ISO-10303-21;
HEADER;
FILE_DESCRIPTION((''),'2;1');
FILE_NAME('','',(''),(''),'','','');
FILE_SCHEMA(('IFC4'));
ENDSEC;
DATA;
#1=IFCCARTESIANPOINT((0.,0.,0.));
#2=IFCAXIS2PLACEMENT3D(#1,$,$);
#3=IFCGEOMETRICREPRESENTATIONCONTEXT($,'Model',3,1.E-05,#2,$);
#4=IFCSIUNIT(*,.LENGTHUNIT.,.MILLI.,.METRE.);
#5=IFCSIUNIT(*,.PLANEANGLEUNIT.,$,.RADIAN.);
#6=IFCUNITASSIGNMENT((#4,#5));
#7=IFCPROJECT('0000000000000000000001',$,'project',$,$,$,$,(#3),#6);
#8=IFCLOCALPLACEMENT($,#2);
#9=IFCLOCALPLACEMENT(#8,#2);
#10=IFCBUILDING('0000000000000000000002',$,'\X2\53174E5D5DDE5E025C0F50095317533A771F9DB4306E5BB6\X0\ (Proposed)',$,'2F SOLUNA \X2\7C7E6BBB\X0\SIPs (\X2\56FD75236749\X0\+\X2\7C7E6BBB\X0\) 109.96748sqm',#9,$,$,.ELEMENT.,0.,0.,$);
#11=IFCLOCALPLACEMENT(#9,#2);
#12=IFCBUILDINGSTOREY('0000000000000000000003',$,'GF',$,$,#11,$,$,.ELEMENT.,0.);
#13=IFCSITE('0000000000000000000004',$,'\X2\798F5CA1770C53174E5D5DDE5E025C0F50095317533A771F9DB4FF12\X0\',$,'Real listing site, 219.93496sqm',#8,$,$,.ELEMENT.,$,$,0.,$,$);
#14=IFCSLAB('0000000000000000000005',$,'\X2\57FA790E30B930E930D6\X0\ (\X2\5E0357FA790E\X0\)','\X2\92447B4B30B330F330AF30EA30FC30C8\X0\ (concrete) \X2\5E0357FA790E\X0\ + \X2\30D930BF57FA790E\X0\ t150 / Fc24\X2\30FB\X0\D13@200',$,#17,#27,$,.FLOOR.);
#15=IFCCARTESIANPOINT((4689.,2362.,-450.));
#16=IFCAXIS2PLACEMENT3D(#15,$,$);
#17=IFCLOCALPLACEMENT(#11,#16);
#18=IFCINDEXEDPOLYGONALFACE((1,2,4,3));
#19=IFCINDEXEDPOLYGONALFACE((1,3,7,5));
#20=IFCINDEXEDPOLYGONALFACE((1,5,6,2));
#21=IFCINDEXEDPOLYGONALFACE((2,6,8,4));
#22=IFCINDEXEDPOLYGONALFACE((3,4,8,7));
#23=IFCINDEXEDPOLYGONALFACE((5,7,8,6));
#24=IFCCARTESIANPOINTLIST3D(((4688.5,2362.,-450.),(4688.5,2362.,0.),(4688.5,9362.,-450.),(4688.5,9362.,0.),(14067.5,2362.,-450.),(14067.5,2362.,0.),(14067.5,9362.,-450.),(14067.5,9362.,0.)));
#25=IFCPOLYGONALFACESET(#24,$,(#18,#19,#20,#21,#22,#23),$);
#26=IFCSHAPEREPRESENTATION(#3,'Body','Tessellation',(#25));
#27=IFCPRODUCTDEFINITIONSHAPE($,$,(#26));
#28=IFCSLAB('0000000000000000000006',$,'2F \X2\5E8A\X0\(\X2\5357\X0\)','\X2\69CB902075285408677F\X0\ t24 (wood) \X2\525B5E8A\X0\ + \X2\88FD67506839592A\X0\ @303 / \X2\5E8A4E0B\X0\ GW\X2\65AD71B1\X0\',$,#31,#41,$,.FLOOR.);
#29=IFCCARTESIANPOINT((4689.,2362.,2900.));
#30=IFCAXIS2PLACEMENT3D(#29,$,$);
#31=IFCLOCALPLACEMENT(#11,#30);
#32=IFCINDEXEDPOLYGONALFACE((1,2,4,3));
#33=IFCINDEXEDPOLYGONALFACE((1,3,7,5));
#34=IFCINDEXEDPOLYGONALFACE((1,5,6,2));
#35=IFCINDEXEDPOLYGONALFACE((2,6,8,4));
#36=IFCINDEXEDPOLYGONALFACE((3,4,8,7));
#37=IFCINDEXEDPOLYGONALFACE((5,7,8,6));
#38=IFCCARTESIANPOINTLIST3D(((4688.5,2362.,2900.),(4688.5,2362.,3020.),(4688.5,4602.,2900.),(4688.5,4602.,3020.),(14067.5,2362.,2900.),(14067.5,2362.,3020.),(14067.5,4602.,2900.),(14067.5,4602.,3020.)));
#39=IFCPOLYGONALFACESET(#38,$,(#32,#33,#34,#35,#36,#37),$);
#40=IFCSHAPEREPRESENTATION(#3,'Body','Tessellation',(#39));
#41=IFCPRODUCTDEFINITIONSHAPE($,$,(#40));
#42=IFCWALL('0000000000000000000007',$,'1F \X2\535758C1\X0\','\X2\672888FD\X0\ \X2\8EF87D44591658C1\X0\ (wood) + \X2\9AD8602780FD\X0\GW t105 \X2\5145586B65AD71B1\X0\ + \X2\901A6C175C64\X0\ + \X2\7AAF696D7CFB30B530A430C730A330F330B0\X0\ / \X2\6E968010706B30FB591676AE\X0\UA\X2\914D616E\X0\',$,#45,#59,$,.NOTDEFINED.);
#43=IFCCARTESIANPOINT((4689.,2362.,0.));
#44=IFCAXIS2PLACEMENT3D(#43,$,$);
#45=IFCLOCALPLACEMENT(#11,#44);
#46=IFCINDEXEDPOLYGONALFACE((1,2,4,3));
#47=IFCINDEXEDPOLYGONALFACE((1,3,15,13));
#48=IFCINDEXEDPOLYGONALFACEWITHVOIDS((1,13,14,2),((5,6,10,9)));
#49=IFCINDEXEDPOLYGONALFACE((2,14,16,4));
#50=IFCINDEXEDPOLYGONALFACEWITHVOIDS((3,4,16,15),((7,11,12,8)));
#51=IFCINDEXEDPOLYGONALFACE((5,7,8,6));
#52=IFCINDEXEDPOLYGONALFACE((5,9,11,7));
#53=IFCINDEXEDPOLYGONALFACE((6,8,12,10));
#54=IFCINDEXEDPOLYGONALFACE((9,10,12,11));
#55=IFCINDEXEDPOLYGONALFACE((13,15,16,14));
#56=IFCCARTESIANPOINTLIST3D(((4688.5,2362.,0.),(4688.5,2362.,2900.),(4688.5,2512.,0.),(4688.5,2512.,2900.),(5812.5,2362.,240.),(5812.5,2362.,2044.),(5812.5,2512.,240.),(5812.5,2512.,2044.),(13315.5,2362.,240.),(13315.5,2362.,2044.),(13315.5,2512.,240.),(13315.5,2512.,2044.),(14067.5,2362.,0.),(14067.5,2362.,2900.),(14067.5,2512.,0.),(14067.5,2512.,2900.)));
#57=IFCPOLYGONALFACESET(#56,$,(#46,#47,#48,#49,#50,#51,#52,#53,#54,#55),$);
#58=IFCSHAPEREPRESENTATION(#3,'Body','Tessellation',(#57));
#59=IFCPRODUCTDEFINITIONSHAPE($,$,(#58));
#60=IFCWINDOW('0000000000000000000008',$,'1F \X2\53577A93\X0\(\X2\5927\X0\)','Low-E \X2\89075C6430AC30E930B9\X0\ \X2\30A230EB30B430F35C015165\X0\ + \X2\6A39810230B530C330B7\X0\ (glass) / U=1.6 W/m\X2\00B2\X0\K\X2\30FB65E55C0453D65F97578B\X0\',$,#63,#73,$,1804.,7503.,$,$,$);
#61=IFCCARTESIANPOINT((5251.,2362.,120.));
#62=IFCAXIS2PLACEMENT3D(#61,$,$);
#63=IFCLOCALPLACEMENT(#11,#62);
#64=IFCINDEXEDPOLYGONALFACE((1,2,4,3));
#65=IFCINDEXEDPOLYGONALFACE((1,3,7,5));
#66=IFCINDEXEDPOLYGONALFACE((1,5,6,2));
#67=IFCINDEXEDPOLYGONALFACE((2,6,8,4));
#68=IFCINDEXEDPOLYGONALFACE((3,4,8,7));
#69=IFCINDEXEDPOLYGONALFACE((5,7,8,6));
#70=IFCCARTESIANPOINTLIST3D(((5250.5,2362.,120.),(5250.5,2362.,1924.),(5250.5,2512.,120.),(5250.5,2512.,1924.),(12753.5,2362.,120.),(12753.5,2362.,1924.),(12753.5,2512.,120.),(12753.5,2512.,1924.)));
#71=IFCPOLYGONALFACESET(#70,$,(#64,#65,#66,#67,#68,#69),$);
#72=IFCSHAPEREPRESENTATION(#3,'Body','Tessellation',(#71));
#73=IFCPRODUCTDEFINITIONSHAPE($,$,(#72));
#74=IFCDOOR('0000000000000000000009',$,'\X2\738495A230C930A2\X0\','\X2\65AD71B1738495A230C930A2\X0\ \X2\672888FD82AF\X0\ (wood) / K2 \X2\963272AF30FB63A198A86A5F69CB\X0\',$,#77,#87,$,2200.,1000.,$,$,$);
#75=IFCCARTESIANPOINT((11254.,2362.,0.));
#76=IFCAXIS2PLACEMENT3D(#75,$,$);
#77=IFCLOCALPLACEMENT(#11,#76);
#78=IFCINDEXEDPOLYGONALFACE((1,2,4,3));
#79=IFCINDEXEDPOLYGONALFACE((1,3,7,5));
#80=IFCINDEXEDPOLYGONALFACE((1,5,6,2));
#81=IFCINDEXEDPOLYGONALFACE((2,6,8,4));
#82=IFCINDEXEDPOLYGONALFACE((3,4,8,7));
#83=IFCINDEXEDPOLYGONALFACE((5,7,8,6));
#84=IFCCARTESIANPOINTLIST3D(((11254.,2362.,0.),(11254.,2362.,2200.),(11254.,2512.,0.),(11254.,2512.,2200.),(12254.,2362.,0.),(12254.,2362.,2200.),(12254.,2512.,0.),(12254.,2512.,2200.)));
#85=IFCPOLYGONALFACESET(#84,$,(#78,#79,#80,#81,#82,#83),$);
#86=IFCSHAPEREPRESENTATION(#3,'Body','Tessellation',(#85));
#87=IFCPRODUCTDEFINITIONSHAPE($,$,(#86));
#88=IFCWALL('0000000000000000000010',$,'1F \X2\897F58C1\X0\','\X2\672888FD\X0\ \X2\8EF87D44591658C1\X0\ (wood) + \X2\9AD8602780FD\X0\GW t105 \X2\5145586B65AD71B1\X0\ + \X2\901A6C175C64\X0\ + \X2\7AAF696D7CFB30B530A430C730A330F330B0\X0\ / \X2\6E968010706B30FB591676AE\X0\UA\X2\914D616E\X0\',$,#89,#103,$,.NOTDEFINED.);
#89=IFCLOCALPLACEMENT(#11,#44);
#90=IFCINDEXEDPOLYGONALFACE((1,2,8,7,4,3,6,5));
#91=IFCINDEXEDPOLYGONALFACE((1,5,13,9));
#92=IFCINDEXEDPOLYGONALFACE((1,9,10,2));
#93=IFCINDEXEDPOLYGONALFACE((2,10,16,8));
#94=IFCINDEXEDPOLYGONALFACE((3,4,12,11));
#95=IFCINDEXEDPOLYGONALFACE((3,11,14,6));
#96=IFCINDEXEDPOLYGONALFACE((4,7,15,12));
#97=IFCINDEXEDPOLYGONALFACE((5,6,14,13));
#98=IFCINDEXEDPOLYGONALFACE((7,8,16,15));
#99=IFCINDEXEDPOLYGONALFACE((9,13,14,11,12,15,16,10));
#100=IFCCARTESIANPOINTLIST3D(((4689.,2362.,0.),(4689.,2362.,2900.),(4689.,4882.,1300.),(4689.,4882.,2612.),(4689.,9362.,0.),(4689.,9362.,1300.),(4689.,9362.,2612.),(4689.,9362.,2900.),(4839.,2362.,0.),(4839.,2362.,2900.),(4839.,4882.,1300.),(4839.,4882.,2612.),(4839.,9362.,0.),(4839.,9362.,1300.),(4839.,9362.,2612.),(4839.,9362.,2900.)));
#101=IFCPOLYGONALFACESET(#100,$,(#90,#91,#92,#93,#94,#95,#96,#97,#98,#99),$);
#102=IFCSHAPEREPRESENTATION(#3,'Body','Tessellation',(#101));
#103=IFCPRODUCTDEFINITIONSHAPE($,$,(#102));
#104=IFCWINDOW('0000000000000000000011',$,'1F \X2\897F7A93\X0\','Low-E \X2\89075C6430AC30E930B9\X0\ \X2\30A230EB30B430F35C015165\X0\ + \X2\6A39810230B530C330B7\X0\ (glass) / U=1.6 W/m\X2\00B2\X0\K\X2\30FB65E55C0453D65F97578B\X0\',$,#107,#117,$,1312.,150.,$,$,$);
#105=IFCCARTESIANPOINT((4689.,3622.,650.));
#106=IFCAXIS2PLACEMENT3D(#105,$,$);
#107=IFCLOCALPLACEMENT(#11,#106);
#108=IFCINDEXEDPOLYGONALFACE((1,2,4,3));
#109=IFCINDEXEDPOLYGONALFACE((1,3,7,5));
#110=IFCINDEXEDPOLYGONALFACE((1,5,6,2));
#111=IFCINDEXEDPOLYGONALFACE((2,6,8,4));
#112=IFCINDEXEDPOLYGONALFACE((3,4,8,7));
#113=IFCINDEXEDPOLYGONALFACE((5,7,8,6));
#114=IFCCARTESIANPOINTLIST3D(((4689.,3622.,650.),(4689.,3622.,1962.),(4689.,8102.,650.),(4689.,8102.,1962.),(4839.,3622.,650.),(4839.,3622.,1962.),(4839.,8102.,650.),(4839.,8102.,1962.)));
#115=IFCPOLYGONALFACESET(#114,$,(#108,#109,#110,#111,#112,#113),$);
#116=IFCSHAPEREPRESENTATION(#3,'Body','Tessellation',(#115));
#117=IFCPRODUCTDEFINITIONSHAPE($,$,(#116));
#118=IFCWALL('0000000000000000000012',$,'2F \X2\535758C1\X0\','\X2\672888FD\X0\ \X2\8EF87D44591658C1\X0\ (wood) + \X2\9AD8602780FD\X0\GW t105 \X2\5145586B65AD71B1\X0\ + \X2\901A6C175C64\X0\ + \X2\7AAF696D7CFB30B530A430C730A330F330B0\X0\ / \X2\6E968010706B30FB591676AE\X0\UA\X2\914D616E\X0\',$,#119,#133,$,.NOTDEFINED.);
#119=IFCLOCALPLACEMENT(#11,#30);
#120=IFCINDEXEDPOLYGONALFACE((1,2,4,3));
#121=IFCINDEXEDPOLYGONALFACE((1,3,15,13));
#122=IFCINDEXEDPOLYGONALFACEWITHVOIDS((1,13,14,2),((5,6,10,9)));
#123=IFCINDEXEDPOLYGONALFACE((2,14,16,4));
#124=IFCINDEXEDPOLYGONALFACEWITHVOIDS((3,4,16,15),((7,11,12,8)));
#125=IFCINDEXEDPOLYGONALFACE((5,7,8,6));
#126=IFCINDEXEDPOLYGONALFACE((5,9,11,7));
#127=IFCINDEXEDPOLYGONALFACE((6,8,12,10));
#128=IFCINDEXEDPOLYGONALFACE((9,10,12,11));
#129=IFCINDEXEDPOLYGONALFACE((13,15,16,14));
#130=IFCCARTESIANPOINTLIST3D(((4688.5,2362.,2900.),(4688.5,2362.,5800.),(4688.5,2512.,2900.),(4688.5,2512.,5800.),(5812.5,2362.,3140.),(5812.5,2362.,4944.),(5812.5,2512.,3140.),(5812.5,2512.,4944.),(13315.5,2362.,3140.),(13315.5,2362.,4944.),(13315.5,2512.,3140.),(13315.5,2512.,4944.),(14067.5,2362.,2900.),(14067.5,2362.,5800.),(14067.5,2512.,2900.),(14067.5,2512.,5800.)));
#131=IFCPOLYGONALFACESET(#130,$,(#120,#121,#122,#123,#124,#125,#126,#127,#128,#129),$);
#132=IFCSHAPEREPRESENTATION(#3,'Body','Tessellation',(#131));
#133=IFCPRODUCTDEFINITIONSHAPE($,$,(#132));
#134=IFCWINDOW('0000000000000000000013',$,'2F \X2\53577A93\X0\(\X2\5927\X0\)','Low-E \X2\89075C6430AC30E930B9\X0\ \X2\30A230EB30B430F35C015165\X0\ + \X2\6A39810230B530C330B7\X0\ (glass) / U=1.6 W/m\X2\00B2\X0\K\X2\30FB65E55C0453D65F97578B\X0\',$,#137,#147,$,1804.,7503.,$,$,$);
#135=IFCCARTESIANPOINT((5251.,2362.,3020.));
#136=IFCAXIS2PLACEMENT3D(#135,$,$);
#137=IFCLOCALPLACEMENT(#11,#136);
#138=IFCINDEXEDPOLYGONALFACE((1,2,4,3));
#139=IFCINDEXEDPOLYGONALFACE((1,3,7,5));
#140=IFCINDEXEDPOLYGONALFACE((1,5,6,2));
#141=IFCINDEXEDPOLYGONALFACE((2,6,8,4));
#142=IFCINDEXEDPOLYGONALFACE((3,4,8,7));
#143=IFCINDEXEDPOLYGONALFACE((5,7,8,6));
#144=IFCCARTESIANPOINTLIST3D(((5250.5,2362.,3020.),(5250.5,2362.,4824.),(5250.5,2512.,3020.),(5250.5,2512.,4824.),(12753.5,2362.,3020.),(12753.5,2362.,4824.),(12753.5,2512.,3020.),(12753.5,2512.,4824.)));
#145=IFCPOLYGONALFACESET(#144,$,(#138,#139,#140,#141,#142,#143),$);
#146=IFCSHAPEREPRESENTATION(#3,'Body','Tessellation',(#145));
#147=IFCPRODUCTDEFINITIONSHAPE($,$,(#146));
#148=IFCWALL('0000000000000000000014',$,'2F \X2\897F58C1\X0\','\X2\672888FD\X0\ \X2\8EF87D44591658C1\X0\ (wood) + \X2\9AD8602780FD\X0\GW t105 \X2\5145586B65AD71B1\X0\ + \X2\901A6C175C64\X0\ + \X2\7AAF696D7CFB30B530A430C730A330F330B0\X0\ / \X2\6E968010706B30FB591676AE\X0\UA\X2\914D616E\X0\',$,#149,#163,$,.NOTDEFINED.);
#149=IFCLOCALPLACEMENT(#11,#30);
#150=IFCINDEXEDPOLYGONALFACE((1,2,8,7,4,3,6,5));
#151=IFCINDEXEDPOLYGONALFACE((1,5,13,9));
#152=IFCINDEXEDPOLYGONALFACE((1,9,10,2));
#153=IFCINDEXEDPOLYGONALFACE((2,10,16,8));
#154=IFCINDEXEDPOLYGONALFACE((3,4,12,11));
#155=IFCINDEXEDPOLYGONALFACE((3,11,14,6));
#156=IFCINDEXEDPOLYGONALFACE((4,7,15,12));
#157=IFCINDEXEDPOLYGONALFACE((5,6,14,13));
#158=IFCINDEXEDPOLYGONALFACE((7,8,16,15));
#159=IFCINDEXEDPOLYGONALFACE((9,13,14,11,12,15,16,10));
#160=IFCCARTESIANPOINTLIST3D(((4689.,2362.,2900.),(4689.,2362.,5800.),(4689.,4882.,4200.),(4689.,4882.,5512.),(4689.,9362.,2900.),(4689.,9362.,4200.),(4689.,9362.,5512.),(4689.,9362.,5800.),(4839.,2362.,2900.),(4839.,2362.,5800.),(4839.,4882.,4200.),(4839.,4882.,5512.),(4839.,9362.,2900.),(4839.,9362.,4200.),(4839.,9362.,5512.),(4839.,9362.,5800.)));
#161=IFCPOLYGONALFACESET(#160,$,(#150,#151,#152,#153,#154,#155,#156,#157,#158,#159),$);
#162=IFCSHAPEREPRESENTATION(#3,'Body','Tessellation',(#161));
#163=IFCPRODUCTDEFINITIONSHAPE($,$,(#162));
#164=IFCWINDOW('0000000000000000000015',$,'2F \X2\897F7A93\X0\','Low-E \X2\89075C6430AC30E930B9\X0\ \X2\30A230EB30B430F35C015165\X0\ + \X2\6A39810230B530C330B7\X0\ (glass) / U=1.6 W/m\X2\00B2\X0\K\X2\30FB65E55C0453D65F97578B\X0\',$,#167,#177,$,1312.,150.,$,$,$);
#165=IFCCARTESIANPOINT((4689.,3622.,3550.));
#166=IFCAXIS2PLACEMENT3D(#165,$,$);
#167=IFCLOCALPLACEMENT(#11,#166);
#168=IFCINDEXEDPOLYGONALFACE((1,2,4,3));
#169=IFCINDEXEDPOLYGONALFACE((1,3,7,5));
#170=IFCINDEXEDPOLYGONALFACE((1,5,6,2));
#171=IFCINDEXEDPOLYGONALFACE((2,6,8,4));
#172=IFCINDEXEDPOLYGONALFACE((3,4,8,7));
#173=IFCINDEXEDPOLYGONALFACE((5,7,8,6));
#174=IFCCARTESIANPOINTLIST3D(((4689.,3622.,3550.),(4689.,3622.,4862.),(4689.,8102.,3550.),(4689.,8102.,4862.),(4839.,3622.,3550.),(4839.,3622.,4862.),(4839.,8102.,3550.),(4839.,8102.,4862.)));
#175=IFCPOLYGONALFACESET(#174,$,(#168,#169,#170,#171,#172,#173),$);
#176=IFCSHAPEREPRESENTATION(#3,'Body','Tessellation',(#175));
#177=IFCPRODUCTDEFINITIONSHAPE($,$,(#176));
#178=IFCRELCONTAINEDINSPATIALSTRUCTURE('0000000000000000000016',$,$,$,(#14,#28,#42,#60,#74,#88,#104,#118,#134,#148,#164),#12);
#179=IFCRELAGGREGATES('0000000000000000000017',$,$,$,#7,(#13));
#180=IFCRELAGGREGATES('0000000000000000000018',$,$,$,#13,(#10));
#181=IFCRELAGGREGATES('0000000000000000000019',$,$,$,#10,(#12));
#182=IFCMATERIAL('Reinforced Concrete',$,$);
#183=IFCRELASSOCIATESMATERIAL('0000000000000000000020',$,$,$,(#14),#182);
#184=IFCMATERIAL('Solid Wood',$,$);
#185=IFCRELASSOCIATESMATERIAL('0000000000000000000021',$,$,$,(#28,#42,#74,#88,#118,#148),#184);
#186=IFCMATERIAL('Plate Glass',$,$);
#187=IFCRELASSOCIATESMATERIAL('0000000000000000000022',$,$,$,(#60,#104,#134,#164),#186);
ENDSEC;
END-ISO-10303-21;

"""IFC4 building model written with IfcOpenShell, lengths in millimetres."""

from ifc_helpers import new_model, si_unit, frame, frame_2d, origin, place, context, project, spatial, rectangle, extrude, material, element, fill, save


model = new_model("IFC4")

# Units and contexts
model_context = context("Model", 3, precision=1e-05, world=origin())
ifc_project = project(units=[si_unit("LENGTHUNIT", "METRE", prefix="MILLI"), si_unit("PLANEANGLEUNIT", "RADIAN")], contexts=[model_context])

# Site, building, storey
site_placement = place(None, origin())
site = spatial("IfcSite", under=ifc_project, at=site_placement, Name="福岡県北九州市小倉北区真鶴２", ObjectType="Real listing site, 219.93496sqm", CompositionType="ELEMENT", RefElevation=0.0)
building_placement = place(site_placement, origin())
building = spatial("IfcBuilding", under=site, at=building_placement, Name="北九州市小倉北区真鶴の家 (Proposed)", ObjectType="2F SOLUNA 籾殻SIPs (国産杉+籾殻) 109.96748sqm", CompositionType="ELEMENT", ElevationOfRefHeight=0.0, ElevationOfTerrain=0.0)
storey_placement = place(building_placement, origin())
storey = spatial("IfcBuildingStorey", under=building, at=storey_placement, Name="GF", CompositionType="ELEMENT", Elevation=0.0)

# Slabs
ifc_material_1 = material(Name="Reinforced Concrete")
slab_1_placement = place(storey_placement, frame((4689.0, 2362.0, -450.0)))
element("IfcSlab", 1, at=slab_1_placement, inside=storey, material=ifc_material_1, Name="基礎スラブ (布基礎)", Description="鉄筋コンクリート (concrete) 布基礎 + ベタ基礎 t150 / Fc24・D13@200", PredefinedType="FLOOR", context=model_context, shape_type="SweptSolid", body=[
    extrude(rectangle(XDim=9379.0, YDim=7000.0, at=frame_2d((4689.0, 3500.0))), frame((4689.0, 2362.0, -450.0)), (0.0, 0.0, 1.0), 450.0),
])
ifc_material_2 = material(Name="Solid Wood")
slab_2_placement = place(storey_placement, frame((4689.0, 2362.0, 2900.0)))
element("IfcSlab", 2, at=slab_2_placement, inside=storey, material=ifc_material_2, Name="2F 床(南)", Description="構造用合板 t24 (wood) 剛床 + 製材根太 @303 / 床下 GW断熱", PredefinedType="FLOOR", context=model_context, shape_type="SweptSolid", body=[
    extrude(rectangle(XDim=9379.0, YDim=2240.0, at=frame_2d((4689.0, 1120.0))), frame((4689.0, 2362.0, 2900.0)), (0.0, 0.0, 1.0), 120.0),
])

# Wall, openings, window, door
wall_1_placement = place(storey_placement, frame((4689.0, 2362.0, 0.0)))
wall_1 = element("IfcWall", 3, at=wall_1_placement, inside=storey, material=ifc_material_2, Name="1F 南壁", Description="木製 軸組外壁 (wood) + 高性能GW t105 充填断熱 + 通気層 + 窯業系サイディング / 準耐火・外皮UA配慮", PredefinedType="NOTDEFINED", context=model_context, shape_type="SweptSolid", body=[
    extrude(rectangle(XDim=9379.0, YDim=150.0, at=frame_2d((4689.0, 75.0))), frame((4689.0, 2362.0, 0.0)), (0.0, 0.0, 1.0), 2900.0),
])
opening_1_placement = place(storey_placement, frame((5251.0, 2362.0, 120.0)))
opening_1 = element("IfcOpeningElement", 4, at=opening_1_placement, cuts=wall_1, PredefinedType="NOTDEFINED", context=model_context, shape_type="SweptSolid", body=[
    extrude(rectangle(XDim=7503.0, YDim=150.0, at=frame_2d((3751.0, 75.0))), frame((5251.0, 2362.0, 120.0)), (0.0, 0.0, 1.0), 1804.0),
])
opening_2_placement = place(storey_placement, frame((11254.0, 2362.0, 0.0)))
opening_2 = element("IfcOpeningElement", 5, at=opening_2_placement, cuts=wall_1, PredefinedType="NOTDEFINED", context=model_context, shape_type="SweptSolid", body=[
    extrude(rectangle(XDim=1000.0, YDim=150.0, at=frame_2d((500.0, 75.0))), frame((11254.0, 2362.0, 0.0)), (0.0, 0.0, 1.0), 2200.0),
])
ifc_material_3 = material(Name="Plate Glass")
window_1_placement = place(storey_placement, frame((5251.0, 2362.0, 120.0)))
window_1 = element("IfcWindow", 6, at=window_1_placement, inside=storey, material=ifc_material_3, Name="1F 南窓(大)", Description="Low-E 複層ガラス アルゴン封入 + 樹脂サッシ (glass) / U=1.6 W/m²K・日射取得型", OverallHeight=1804.0, OverallWidth=7503.0, context=model_context, shape_type="SweptSolid", body=[
    extrude(rectangle(XDim=7503.0, YDim=150.0, at=frame_2d((3751.0, 75.0))), frame((5251.0, 2362.0, 120.0)), (0.0, 0.0, 1.0), 1804.0),
])
fill(opening_1, window_1)
door_placement = place(storey_placement, frame((11254.0, 2362.0, 0.0)))
door = element("IfcDoor", 7, at=door_placement, inside=storey, material=ifc_material_2, Name="玄関ドア", Description="断熱玄関ドア 木製芯 (wood) / K2 防犯・採風機構", OverallHeight=2200.0, OverallWidth=1000.0, context=model_context, shape_type="SweptSolid", body=[
    extrude(rectangle(XDim=1000.0, YDim=150.0, at=frame_2d((500.0, 75.0))), frame((11254.0, 2362.0, 0.0)), (0.0, 0.0, 1.0), 2200.0),
])
fill(opening_2, door)

# Walls, openings, windows
wall_2_placement = place(storey_placement, frame((4689.0, 2362.0, 0.0)))
wall_2 = element("IfcWall", 8, at=wall_2_placement, inside=storey, material=ifc_material_2, Name="1F 西壁", Description="木製 軸組外壁 (wood) + 高性能GW t105 充填断熱 + 通気層 + 窯業系サイディング / 準耐火・外皮UA配慮", PredefinedType="NOTDEFINED", context=model_context, shape_type="SweptSolid", body=[
    extrude(rectangle(XDim=150.0, YDim=7000.0, at=frame_2d((75.0, 3500.0))), frame((4689.0, 2362.0, 0.0)), (0.0, 0.0, 1.0), 2900.0),
])
opening_3_placement = place(storey_placement, frame((4689.0, 3622.0, 650.0)))
opening_3 = element("IfcOpeningElement", 9, at=opening_3_placement, cuts=wall_2, PredefinedType="NOTDEFINED", context=model_context, shape_type="SweptSolid", body=[
    extrude(rectangle(XDim=150.0, YDim=4480.0, at=frame_2d((75.0, 2240.0))), frame((4689.0, 3622.0, 650.0)), (0.0, 0.0, 1.0), 1312.0),
])
window_2_placement = place(storey_placement, frame((4689.0, 3622.0, 650.0)))
window_2 = element("IfcWindow", 10, at=window_2_placement, inside=storey, material=ifc_material_3, Name="1F 西窓", Description="Low-E 複層ガラス アルゴン封入 + 樹脂サッシ (glass) / U=1.6 W/m²K・日射取得型", OverallHeight=1312.0, OverallWidth=150.0, context=model_context, shape_type="SweptSolid", body=[
    extrude(rectangle(XDim=150.0, YDim=4480.0, at=frame_2d((75.0, 2240.0))), frame((4689.0, 3622.0, 650.0)), (0.0, 0.0, 1.0), 1312.0),
])
fill(opening_3, window_2)
wall_3_placement = place(storey_placement, frame((4689.0, 2362.0, 2900.0)))
wall_3 = element("IfcWall", 11, at=wall_3_placement, inside=storey, material=ifc_material_2, Name="2F 南壁", Description="木製 軸組外壁 (wood) + 高性能GW t105 充填断熱 + 通気層 + 窯業系サイディング / 準耐火・外皮UA配慮", PredefinedType="NOTDEFINED", context=model_context, shape_type="SweptSolid", body=[
    extrude(rectangle(XDim=9379.0, YDim=150.0, at=frame_2d((4689.0, 75.0))), frame((4689.0, 2362.0, 2900.0)), (0.0, 0.0, 1.0), 2900.0),
])
opening_4_placement = place(storey_placement, frame((5251.0, 2362.0, 3020.0)))
opening_4 = element("IfcOpeningElement", 12, at=opening_4_placement, cuts=wall_3, PredefinedType="NOTDEFINED", context=model_context, shape_type="SweptSolid", body=[
    extrude(rectangle(XDim=7503.0, YDim=150.0, at=frame_2d((3751.0, 75.0))), frame((5251.0, 2362.0, 3020.0)), (0.0, 0.0, 1.0), 1804.0),
])
window_3_placement = place(storey_placement, frame((5251.0, 2362.0, 3020.0)))
window_3 = element("IfcWindow", 13, at=window_3_placement, inside=storey, material=ifc_material_3, Name="2F 南窓(大)", Description="Low-E 複層ガラス アルゴン封入 + 樹脂サッシ (glass) / U=1.6 W/m²K・日射取得型", OverallHeight=1804.0, OverallWidth=7503.0, context=model_context, shape_type="SweptSolid", body=[
    extrude(rectangle(XDim=7503.0, YDim=150.0, at=frame_2d((3751.0, 75.0))), frame((5251.0, 2362.0, 3020.0)), (0.0, 0.0, 1.0), 1804.0),
])
fill(opening_4, window_3)
wall_4_placement = place(storey_placement, frame((4689.0, 2362.0, 2900.0)))
wall_4 = element("IfcWall", 14, at=wall_4_placement, inside=storey, material=ifc_material_2, Name="2F 西壁", Description="木製 軸組外壁 (wood) + 高性能GW t105 充填断熱 + 通気層 + 窯業系サイディング / 準耐火・外皮UA配慮", PredefinedType="NOTDEFINED", context=model_context, shape_type="SweptSolid", body=[
    extrude(rectangle(XDim=150.0, YDim=7000.0, at=frame_2d((75.0, 3500.0))), frame((4689.0, 2362.0, 2900.0)), (0.0, 0.0, 1.0), 2900.0),
])
opening_5_placement = place(storey_placement, frame((4689.0, 3622.0, 3550.0)))
opening_5 = element("IfcOpeningElement", 15, at=opening_5_placement, cuts=wall_4, PredefinedType="NOTDEFINED", context=model_context, shape_type="SweptSolid", body=[
    extrude(rectangle(XDim=150.0, YDim=4480.0, at=frame_2d((75.0, 2240.0))), frame((4689.0, 3622.0, 3550.0)), (0.0, 0.0, 1.0), 1312.0),
])
window_4_placement = place(storey_placement, frame((4689.0, 3622.0, 3550.0)))
window_4 = element("IfcWindow", 16, at=window_4_placement, inside=storey, material=ifc_material_3, Name="2F 西窓", Description="Low-E 複層ガラス アルゴン封入 + 樹脂サッシ (glass) / U=1.6 W/m²K・日射取得型", OverallHeight=1312.0, OverallWidth=150.0, context=model_context, shape_type="SweptSolid", body=[
    extrude(rectangle(XDim=150.0, YDim=4480.0, at=frame_2d((75.0, 2240.0))), frame((4689.0, 3622.0, 3550.0)), (0.0, 0.0, 1.0), 1312.0),
])
fill(opening_5, window_4)

save(model, "model.ifc")
